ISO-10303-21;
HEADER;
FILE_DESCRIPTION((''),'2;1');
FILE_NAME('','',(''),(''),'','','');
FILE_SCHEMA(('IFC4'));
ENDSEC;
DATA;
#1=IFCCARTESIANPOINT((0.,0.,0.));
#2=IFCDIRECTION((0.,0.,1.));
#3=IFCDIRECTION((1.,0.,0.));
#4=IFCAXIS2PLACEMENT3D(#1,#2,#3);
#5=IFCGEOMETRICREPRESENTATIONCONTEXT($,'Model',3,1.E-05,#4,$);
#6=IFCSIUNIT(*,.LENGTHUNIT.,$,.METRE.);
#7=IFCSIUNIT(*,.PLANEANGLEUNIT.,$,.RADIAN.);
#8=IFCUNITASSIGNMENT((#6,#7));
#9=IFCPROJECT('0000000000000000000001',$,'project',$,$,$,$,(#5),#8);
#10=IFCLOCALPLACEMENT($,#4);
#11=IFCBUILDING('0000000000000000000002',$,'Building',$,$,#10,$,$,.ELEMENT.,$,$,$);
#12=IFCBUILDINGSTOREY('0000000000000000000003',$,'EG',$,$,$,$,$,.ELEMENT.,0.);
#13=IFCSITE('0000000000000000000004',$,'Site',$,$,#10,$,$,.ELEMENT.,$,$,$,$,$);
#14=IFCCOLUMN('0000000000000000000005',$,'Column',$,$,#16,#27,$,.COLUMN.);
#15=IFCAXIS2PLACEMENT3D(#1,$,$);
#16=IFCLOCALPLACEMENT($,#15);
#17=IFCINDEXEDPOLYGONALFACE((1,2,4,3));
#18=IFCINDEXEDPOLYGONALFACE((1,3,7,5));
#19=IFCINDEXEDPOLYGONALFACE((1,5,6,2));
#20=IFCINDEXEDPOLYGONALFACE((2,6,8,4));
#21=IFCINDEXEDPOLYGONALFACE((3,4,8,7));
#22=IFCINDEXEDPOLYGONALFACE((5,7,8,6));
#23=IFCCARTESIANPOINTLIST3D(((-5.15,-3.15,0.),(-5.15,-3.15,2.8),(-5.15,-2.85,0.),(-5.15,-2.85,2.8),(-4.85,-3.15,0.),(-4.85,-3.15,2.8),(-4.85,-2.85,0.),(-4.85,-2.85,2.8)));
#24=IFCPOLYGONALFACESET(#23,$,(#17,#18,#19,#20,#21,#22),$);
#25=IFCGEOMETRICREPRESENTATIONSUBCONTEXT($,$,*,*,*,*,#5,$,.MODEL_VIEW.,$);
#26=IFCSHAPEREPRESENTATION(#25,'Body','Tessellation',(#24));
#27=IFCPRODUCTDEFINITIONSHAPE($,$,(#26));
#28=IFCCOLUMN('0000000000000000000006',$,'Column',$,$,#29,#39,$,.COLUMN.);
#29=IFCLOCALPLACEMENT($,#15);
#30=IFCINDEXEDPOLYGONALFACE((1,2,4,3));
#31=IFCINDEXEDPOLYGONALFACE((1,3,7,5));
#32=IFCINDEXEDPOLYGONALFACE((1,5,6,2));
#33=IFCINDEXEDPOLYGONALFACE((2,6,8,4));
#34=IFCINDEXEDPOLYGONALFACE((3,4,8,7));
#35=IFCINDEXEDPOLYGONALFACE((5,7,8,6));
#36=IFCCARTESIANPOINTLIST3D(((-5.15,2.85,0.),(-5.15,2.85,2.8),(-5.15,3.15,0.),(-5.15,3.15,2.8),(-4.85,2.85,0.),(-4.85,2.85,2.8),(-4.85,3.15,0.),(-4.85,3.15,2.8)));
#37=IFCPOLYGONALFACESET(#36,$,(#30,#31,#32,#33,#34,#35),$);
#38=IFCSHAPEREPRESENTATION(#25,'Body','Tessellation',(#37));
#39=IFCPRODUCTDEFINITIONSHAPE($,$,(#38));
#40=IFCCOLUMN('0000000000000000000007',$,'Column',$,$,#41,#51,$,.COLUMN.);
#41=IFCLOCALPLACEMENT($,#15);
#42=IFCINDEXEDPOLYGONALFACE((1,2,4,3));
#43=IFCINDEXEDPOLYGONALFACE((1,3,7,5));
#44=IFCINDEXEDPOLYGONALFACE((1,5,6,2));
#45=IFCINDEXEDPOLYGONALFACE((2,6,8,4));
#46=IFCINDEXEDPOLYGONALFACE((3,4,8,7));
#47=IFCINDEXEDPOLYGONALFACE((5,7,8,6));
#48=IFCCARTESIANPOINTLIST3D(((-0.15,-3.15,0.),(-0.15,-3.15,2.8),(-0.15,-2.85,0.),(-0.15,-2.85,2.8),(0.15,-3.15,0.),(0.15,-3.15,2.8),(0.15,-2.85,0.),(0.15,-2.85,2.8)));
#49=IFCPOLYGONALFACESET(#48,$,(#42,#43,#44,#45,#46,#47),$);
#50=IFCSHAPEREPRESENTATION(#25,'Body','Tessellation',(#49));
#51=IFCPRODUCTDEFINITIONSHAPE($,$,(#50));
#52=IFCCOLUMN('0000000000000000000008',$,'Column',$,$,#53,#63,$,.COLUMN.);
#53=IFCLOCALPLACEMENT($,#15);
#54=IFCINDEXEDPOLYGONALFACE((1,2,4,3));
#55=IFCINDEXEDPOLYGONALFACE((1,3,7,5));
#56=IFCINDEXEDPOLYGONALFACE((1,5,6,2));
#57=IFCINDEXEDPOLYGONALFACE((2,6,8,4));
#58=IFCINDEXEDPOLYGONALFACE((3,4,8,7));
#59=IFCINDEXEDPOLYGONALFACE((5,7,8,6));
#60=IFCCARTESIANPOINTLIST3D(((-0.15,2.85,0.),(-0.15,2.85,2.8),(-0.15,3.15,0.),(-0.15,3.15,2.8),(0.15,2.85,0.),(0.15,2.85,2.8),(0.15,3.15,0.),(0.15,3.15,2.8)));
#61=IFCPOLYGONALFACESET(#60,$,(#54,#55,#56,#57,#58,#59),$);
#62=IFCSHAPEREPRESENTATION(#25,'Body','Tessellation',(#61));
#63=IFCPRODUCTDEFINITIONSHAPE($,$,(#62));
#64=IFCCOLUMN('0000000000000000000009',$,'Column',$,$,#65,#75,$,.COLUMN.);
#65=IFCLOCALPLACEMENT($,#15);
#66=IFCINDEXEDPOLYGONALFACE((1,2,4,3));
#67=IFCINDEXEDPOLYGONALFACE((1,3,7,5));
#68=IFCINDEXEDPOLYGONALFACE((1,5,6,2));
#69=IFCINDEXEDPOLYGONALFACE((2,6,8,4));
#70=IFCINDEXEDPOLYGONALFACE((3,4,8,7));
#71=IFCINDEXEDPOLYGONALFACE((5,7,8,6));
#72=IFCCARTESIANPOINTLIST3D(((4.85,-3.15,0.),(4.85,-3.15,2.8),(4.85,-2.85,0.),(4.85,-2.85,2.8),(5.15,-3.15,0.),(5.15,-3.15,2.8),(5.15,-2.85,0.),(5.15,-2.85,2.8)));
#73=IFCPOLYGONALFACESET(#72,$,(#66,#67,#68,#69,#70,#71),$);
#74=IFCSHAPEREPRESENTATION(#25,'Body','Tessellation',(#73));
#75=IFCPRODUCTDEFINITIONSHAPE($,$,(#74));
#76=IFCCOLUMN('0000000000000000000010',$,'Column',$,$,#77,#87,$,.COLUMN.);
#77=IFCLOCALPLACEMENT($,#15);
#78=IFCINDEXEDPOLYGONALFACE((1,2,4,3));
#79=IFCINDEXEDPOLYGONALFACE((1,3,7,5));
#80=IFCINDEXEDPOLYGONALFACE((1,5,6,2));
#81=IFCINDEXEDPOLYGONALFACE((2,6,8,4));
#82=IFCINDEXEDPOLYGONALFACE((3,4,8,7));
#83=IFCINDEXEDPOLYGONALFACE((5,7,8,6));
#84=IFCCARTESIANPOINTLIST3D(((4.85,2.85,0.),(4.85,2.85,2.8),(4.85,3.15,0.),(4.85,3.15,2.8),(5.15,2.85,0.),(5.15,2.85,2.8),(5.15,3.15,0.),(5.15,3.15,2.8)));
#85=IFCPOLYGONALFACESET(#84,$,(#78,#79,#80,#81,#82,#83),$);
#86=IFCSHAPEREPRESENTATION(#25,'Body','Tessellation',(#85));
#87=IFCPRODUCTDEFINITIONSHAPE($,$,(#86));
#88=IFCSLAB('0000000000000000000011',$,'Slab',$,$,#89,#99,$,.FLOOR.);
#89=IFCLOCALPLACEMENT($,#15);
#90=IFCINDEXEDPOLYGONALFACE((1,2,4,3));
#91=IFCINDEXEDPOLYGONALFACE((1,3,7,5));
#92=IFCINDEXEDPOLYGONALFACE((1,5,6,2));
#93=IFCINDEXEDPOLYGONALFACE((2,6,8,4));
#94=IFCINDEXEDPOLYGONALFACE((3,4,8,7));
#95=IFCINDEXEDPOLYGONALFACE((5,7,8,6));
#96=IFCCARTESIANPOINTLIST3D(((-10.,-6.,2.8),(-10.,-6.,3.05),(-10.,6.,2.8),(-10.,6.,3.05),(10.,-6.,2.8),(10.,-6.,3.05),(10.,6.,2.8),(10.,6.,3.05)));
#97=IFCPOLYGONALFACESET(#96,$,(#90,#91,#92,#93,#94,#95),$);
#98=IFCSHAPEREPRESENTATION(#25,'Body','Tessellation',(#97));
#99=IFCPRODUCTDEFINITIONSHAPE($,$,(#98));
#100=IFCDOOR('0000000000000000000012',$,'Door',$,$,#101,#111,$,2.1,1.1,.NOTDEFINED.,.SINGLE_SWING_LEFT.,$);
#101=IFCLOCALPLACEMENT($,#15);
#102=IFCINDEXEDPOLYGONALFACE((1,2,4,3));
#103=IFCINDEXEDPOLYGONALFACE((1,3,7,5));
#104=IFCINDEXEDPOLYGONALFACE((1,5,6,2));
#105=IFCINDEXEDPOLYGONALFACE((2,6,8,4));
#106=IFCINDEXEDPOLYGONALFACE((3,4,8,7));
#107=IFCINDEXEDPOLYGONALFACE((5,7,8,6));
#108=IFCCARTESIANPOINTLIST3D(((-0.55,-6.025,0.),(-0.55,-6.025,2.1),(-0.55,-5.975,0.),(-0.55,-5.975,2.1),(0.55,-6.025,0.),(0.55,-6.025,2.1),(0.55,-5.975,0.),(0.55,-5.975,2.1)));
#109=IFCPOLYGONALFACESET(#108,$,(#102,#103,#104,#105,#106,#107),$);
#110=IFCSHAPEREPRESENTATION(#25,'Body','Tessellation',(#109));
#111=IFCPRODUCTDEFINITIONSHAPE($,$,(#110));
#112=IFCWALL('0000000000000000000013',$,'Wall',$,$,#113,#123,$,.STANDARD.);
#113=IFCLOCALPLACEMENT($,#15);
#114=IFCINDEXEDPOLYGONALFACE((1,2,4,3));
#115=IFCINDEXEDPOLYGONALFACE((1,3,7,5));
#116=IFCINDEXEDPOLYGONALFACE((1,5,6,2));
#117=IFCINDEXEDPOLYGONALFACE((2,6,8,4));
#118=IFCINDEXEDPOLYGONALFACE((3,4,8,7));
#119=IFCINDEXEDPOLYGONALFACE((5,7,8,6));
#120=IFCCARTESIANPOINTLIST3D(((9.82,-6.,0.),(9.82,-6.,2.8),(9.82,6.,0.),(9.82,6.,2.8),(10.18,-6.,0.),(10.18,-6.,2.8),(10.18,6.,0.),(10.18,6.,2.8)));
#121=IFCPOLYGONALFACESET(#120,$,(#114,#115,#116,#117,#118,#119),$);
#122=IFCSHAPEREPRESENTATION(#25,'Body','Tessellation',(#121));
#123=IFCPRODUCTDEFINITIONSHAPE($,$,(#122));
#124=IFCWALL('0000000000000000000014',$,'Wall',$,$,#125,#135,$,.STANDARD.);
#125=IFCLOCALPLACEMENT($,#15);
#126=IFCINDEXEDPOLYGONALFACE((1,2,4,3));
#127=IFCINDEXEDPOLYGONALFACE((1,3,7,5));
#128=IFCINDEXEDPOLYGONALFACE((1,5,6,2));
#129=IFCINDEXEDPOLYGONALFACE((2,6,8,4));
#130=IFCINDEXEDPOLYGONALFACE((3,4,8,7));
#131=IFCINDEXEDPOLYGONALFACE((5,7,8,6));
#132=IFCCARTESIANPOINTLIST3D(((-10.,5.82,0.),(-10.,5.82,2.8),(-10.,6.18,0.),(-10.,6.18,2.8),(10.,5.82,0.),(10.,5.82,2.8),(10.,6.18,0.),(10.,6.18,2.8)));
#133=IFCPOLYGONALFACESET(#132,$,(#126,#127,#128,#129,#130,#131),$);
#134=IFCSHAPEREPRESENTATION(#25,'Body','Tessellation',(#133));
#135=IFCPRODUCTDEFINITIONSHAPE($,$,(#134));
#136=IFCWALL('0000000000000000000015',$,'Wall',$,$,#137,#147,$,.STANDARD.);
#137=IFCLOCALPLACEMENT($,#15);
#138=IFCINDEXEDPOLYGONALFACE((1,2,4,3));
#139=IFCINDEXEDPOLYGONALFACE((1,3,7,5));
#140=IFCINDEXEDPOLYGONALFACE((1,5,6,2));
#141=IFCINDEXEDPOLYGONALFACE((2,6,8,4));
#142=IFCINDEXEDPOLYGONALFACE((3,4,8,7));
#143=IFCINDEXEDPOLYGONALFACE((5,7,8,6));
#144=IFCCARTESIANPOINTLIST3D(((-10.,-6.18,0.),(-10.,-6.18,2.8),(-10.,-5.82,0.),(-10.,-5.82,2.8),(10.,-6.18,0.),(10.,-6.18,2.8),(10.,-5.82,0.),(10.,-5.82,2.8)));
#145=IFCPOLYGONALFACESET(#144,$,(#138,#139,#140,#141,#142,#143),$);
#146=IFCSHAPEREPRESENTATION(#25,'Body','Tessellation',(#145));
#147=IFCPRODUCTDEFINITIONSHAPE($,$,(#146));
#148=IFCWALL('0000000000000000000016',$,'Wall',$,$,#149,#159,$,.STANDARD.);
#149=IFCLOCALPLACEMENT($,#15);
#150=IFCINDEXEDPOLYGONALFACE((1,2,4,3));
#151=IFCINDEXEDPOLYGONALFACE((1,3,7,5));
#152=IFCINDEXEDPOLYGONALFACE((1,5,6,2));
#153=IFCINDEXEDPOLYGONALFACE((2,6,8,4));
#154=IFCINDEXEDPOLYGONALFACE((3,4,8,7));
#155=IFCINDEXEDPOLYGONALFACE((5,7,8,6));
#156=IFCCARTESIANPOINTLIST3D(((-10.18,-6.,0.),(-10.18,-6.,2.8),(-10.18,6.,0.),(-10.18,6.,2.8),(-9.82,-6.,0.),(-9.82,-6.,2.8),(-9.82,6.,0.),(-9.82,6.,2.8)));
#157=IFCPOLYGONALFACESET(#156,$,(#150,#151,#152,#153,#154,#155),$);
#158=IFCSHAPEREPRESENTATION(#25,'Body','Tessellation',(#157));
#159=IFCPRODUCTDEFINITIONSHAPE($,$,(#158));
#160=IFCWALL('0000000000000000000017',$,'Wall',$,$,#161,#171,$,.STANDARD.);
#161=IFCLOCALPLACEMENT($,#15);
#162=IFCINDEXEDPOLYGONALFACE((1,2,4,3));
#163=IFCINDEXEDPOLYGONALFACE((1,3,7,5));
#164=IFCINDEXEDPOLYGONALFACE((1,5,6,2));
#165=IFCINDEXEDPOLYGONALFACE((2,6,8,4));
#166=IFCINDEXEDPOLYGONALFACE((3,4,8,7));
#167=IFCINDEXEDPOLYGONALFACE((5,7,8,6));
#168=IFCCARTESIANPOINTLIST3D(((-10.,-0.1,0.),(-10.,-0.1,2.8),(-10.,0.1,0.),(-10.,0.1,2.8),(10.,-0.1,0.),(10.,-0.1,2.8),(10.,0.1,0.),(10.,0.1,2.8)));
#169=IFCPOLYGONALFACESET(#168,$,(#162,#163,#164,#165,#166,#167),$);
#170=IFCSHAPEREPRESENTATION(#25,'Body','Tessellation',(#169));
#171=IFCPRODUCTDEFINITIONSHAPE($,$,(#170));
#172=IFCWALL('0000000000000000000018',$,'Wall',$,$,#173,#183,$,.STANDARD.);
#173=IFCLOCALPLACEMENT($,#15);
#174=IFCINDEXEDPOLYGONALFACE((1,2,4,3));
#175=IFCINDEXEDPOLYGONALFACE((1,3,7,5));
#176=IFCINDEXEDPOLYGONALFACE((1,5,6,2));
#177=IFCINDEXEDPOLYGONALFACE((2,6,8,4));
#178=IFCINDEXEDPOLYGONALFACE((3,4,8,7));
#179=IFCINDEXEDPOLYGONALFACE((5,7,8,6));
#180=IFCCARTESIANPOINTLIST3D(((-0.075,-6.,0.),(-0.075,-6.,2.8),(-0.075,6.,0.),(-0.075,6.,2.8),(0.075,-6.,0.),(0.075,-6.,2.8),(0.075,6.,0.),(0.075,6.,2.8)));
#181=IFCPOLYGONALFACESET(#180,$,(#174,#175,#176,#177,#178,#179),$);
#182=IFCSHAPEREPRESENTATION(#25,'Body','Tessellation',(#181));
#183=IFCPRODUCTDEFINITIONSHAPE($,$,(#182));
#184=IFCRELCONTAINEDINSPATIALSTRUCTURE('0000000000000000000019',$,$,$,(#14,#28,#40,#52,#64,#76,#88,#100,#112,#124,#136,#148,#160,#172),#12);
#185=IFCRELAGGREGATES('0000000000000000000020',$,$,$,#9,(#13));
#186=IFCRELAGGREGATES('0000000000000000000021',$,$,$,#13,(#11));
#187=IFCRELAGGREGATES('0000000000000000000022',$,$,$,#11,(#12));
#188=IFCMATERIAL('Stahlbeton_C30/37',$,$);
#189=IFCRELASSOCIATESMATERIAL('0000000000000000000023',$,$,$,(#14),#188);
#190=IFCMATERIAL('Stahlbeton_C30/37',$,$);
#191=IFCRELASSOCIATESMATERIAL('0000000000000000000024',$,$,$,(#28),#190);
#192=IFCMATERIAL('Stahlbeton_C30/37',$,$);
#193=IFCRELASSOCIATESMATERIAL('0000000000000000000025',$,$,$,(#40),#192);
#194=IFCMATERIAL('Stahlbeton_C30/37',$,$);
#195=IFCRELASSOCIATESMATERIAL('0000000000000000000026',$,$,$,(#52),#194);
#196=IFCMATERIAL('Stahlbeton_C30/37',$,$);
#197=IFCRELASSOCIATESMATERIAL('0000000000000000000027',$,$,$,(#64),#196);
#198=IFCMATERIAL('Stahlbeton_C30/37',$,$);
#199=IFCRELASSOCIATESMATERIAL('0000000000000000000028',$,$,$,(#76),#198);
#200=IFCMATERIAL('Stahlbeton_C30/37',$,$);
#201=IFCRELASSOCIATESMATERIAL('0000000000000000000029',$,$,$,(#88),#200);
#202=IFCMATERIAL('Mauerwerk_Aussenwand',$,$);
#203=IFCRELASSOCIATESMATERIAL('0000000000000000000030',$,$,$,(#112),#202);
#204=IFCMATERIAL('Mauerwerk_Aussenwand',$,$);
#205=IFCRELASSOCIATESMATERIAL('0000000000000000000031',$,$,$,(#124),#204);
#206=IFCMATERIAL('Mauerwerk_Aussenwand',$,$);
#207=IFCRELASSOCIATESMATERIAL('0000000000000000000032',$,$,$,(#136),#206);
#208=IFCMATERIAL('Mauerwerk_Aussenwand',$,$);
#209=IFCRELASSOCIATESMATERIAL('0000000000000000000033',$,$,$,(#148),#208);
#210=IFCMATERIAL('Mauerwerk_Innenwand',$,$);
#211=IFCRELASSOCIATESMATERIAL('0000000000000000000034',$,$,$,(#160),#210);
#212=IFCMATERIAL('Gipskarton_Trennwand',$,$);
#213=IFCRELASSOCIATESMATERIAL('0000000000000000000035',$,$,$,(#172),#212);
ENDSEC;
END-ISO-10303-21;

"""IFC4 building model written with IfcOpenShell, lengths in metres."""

from ifc_helpers import new_model, si_unit, frame, frame_2d, origin, origin_with_axes, origin_2d, place, context, subcontext, project, spatial, rectangle, extrude, material, element, save


model = new_model("IFC4")

# Units and contexts
model_context = context("Model", 3, precision=1e-05, world=origin_with_axes())
sub_context = subcontext(model_context, None, None, "MODEL_VIEW")
ifc_project = project(units=[si_unit("LENGTHUNIT", "METRE"), si_unit("PLANEANGLEUNIT", "RADIAN")], contexts=[model_context])

# Site, building, storey
placement_1 = place(None, origin_with_axes())
site = spatial("IfcSite", under=ifc_project, at=placement_1, Name="Site", CompositionType="ELEMENT")
building = spatial("IfcBuilding", under=site, at=placement_1, Name="Building", CompositionType="ELEMENT")
storey = spatial("IfcBuildingStorey", under=building, Name="EG", CompositionType="ELEMENT", Elevation=0.0)

# Columns
ifc_material_1 = material(Name="Stahlbeton_C30/37")
placement_2 = place(placement_1, origin())
column_1_placement = place(placement_2, frame((-5.0, -3.0, 0.0)))
element("IfcColumn", 1, at=column_1_placement, inside=storey, material=ifc_material_1, Name="Column", PredefinedType="COLUMN", context=sub_context, shape_type="SweptSolid", body=[
    extrude(rectangle(XDim=0.3, YDim=0.3, at=origin_2d()), origin(), (0.0, 0.0, 1.0), 2.8),
])
ifc_material_2 = material(Name="Stahlbeton_C30/37")
placement_3 = place(None, origin_with_axes())
placement_4 = place(placement_3, origin())
column_2_placement = place(placement_4, frame((-5.0, 3.0, 0.0)))
element("IfcColumn", 2, at=column_2_placement, inside=storey, material=ifc_material_2, Name="Column", PredefinedType="COLUMN", context=sub_context, shape_type="SweptSolid", body=[
    extrude(rectangle(XDim=0.3, YDim=0.3, at=origin_2d()), origin(), (0.0, 0.0, 1.0), 2.8),
])
ifc_material_3 = material(Name="Stahlbeton_C30/37")
placement_5 = place(None, origin_with_axes())
placement_6 = place(placement_5, origin())
column_3_placement = place(placement_6, frame((0.0, -3.0, 0.0)))
element("IfcColumn", 3, at=column_3_placement, inside=storey, material=ifc_material_3, Name="Column", PredefinedType="COLUMN", context=sub_context, shape_type="SweptSolid", body=[
    extrude(rectangle(XDim=0.3, YDim=0.3, at=origin_2d()), origin(), (0.0, 0.0, 1.0), 2.8),
])
ifc_material_4 = material(Name="Stahlbeton_C30/37")
placement_7 = place(None, origin_with_axes())
placement_8 = place(placement_7, origin())
column_4_placement = place(placement_8, frame((0.0, 3.0, 0.0)))
element("IfcColumn", 4, at=column_4_placement, inside=storey, material=ifc_material_4, Name="Column", PredefinedType="COLUMN", context=sub_context, shape_type="SweptSolid", body=[
    extrude(rectangle(XDim=0.3, YDim=0.3, at=origin_2d()), origin(), (0.0, 0.0, 1.0), 2.8),
])
ifc_material_5 = material(Name="Stahlbeton_C30/37")
placement_9 = place(None, origin_with_axes())
placement_10 = place(placement_9, origin())
column_5_placement = place(placement_10, frame((5.0, -3.0, 0.0)))
element("IfcColumn", 5, at=column_5_placement, inside=storey, material=ifc_material_5, Name="Column", PredefinedType="COLUMN", context=sub_context, shape_type="SweptSolid", body=[
    extrude(rectangle(XDim=0.3, YDim=0.3, at=origin_2d()), origin(), (0.0, 0.0, 1.0), 2.8),
])
ifc_material_6 = material(Name="Stahlbeton_C30/37")
placement_11 = place(None, origin_with_axes())
placement_12 = place(placement_11, origin())
column_6_placement = place(placement_12, frame((5.0, 3.0, 0.0)))
element("IfcColumn", 6, at=column_6_placement, inside=storey, material=ifc_material_6, Name="Column", PredefinedType="COLUMN", context=sub_context, shape_type="SweptSolid", body=[
    extrude(rectangle(XDim=0.3, YDim=0.3, at=origin_2d()), origin(), (0.0, 0.0, 1.0), 2.8),
])

# Slab
ifc_material_7 = material(Name="Stahlbeton_C30/37")
placement_13 = place(None, origin_with_axes())
placement_14 = place(placement_13, origin())
slab_placement = place(placement_14, frame((-10.0, -6.0, 2.8)))
element("IfcSlab", 7, at=slab_placement, inside=storey, material=ifc_material_7, Name="Slab", PredefinedType="FLOOR", context=sub_context, shape_type="SweptSolid", body=[
    extrude(rectangle(XDim=20.0, YDim=12.0, at=frame_2d((10.0, 6.0))), origin(), (0.0, 0.0, 1.0), 0.25),
])

# Door
placement_15 = place(None, origin_with_axes())
door_placement = place(placement_15, frame((0.0, -6.0, 0.0)))
element("IfcDoor", 8, at=door_placement, inside=storey, Name="Door", OperationType="SINGLE_SWING_LEFT", OverallHeight=2.1, OverallWidth=1.1, PredefinedType="NOTDEFINED", context=sub_context, shape_type="SweptSolid", body=[
    extrude(rectangle(XDim=1.1, YDim=0.05, at=origin_2d()), origin(), (0.0, 0.0, 1.0), 2.1),
])

# Walls
ifc_material_8 = material(Name="Mauerwerk_Aussenwand")
placement_16 = place(None, origin_with_axes())
placement_17 = place(placement_16, origin())
wall_1_placement = place(placement_17, frame((10.0, -6.0, 0.0), x_axis=(0.0, 1.0, 0.0)))
element("IfcWall", 9, at=wall_1_placement, inside=storey, material=ifc_material_8, Name="Wall", PredefinedType="STANDARD", context=sub_context, shape_type="SweptSolid", body=[
    extrude(rectangle(XDim=12.0, YDim=0.36, at=frame_2d((6.0, 0.0))), origin(), (0.0, 0.0, 1.0), 2.8),
])
ifc_material_9 = material(Name="Mauerwerk_Aussenwand")
placement_18 = place(None, origin_with_axes())
placement_19 = place(placement_18, origin())
wall_2_placement = place(placement_19, frame((-10.0, 6.0, 0.0), x_axis=(1.0, 0.0, 0.0)))
element("IfcWall", 10, at=wall_2_placement, inside=storey, material=ifc_material_9, Name="Wall", PredefinedType="STANDARD", context=sub_context, shape_type="SweptSolid", body=[
    extrude(rectangle(XDim=20.0, YDim=0.36, at=frame_2d((10.0, 0.0))), origin(), (0.0, 0.0, 1.0), 2.8),
])
ifc_material_10 = material(Name="Mauerwerk_Aussenwand")
placement_20 = place(None, origin_with_axes())
placement_21 = place(placement_20, origin())
wall_3_placement = place(placement_21, frame((-10.0, -6.0, 0.0), x_axis=(1.0, 0.0, 0.0)))
element("IfcWall", 11, at=wall_3_placement, inside=storey, material=ifc_material_10, Name="Wall", PredefinedType="STANDARD", context=sub_context, shape_type="SweptSolid", body=[
    extrude(rectangle(XDim=20.0, YDim=0.36, at=frame_2d((10.0, 0.0))), origin(), (0.0, 0.0, 1.0), 2.8),
])
ifc_material_11 = material(Name="Mauerwerk_Aussenwand")
placement_22 = place(None, origin_with_axes())
placement_23 = place(placement_22, origin())
wall_4_placement = place(placement_23, frame((-10.0, -6.0, 0.0), x_axis=(0.0, 1.0, 0.0)))
element("IfcWall", 12, at=wall_4_placement, inside=storey, material=ifc_material_11, Name="Wall", PredefinedType="STANDARD", context=sub_context, shape_type="SweptSolid", body=[
    extrude(rectangle(XDim=12.0, YDim=0.36, at=frame_2d((6.0, 0.0))), origin(), (0.0, 0.0, 1.0), 2.8),
])
ifc_material_12 = material(Name="Mauerwerk_Innenwand")
placement_24 = place(None, origin_with_axes())
placement_25 = place(placement_24, origin())
wall_5_placement = place(placement_25, frame((-10.0, 0.0, 0.0), x_axis=(1.0, 0.0, 0.0)))
element("IfcWall", 13, at=wall_5_placement, inside=storey, material=ifc_material_12, Name="Wall", PredefinedType="STANDARD", context=sub_context, shape_type="SweptSolid", body=[
    extrude(rectangle(XDim=20.0, YDim=0.2, at=frame_2d((10.0, 0.0))), origin(), (0.0, 0.0, 1.0), 2.8),
])
ifc_material_13 = material(Name="Gipskarton_Trennwand")
placement_26 = place(None, origin_with_axes())
placement_27 = place(placement_26, origin())
wall_6_placement = place(placement_27, frame((0.0, -6.0, 0.0), x_axis=(0.0, 1.0, 0.0)))
element("IfcWall", 14, at=wall_6_placement, inside=storey, material=ifc_material_13, Name="Wall", PredefinedType="STANDARD", context=sub_context, shape_type="SweptSolid", body=[
    extrude(rectangle(XDim=12.0, YDim=0.15, at=frame_2d((6.0, 0.0))), origin(), (0.0, 0.0, 1.0), 2.8),
])

save(model, "model.ifc")
